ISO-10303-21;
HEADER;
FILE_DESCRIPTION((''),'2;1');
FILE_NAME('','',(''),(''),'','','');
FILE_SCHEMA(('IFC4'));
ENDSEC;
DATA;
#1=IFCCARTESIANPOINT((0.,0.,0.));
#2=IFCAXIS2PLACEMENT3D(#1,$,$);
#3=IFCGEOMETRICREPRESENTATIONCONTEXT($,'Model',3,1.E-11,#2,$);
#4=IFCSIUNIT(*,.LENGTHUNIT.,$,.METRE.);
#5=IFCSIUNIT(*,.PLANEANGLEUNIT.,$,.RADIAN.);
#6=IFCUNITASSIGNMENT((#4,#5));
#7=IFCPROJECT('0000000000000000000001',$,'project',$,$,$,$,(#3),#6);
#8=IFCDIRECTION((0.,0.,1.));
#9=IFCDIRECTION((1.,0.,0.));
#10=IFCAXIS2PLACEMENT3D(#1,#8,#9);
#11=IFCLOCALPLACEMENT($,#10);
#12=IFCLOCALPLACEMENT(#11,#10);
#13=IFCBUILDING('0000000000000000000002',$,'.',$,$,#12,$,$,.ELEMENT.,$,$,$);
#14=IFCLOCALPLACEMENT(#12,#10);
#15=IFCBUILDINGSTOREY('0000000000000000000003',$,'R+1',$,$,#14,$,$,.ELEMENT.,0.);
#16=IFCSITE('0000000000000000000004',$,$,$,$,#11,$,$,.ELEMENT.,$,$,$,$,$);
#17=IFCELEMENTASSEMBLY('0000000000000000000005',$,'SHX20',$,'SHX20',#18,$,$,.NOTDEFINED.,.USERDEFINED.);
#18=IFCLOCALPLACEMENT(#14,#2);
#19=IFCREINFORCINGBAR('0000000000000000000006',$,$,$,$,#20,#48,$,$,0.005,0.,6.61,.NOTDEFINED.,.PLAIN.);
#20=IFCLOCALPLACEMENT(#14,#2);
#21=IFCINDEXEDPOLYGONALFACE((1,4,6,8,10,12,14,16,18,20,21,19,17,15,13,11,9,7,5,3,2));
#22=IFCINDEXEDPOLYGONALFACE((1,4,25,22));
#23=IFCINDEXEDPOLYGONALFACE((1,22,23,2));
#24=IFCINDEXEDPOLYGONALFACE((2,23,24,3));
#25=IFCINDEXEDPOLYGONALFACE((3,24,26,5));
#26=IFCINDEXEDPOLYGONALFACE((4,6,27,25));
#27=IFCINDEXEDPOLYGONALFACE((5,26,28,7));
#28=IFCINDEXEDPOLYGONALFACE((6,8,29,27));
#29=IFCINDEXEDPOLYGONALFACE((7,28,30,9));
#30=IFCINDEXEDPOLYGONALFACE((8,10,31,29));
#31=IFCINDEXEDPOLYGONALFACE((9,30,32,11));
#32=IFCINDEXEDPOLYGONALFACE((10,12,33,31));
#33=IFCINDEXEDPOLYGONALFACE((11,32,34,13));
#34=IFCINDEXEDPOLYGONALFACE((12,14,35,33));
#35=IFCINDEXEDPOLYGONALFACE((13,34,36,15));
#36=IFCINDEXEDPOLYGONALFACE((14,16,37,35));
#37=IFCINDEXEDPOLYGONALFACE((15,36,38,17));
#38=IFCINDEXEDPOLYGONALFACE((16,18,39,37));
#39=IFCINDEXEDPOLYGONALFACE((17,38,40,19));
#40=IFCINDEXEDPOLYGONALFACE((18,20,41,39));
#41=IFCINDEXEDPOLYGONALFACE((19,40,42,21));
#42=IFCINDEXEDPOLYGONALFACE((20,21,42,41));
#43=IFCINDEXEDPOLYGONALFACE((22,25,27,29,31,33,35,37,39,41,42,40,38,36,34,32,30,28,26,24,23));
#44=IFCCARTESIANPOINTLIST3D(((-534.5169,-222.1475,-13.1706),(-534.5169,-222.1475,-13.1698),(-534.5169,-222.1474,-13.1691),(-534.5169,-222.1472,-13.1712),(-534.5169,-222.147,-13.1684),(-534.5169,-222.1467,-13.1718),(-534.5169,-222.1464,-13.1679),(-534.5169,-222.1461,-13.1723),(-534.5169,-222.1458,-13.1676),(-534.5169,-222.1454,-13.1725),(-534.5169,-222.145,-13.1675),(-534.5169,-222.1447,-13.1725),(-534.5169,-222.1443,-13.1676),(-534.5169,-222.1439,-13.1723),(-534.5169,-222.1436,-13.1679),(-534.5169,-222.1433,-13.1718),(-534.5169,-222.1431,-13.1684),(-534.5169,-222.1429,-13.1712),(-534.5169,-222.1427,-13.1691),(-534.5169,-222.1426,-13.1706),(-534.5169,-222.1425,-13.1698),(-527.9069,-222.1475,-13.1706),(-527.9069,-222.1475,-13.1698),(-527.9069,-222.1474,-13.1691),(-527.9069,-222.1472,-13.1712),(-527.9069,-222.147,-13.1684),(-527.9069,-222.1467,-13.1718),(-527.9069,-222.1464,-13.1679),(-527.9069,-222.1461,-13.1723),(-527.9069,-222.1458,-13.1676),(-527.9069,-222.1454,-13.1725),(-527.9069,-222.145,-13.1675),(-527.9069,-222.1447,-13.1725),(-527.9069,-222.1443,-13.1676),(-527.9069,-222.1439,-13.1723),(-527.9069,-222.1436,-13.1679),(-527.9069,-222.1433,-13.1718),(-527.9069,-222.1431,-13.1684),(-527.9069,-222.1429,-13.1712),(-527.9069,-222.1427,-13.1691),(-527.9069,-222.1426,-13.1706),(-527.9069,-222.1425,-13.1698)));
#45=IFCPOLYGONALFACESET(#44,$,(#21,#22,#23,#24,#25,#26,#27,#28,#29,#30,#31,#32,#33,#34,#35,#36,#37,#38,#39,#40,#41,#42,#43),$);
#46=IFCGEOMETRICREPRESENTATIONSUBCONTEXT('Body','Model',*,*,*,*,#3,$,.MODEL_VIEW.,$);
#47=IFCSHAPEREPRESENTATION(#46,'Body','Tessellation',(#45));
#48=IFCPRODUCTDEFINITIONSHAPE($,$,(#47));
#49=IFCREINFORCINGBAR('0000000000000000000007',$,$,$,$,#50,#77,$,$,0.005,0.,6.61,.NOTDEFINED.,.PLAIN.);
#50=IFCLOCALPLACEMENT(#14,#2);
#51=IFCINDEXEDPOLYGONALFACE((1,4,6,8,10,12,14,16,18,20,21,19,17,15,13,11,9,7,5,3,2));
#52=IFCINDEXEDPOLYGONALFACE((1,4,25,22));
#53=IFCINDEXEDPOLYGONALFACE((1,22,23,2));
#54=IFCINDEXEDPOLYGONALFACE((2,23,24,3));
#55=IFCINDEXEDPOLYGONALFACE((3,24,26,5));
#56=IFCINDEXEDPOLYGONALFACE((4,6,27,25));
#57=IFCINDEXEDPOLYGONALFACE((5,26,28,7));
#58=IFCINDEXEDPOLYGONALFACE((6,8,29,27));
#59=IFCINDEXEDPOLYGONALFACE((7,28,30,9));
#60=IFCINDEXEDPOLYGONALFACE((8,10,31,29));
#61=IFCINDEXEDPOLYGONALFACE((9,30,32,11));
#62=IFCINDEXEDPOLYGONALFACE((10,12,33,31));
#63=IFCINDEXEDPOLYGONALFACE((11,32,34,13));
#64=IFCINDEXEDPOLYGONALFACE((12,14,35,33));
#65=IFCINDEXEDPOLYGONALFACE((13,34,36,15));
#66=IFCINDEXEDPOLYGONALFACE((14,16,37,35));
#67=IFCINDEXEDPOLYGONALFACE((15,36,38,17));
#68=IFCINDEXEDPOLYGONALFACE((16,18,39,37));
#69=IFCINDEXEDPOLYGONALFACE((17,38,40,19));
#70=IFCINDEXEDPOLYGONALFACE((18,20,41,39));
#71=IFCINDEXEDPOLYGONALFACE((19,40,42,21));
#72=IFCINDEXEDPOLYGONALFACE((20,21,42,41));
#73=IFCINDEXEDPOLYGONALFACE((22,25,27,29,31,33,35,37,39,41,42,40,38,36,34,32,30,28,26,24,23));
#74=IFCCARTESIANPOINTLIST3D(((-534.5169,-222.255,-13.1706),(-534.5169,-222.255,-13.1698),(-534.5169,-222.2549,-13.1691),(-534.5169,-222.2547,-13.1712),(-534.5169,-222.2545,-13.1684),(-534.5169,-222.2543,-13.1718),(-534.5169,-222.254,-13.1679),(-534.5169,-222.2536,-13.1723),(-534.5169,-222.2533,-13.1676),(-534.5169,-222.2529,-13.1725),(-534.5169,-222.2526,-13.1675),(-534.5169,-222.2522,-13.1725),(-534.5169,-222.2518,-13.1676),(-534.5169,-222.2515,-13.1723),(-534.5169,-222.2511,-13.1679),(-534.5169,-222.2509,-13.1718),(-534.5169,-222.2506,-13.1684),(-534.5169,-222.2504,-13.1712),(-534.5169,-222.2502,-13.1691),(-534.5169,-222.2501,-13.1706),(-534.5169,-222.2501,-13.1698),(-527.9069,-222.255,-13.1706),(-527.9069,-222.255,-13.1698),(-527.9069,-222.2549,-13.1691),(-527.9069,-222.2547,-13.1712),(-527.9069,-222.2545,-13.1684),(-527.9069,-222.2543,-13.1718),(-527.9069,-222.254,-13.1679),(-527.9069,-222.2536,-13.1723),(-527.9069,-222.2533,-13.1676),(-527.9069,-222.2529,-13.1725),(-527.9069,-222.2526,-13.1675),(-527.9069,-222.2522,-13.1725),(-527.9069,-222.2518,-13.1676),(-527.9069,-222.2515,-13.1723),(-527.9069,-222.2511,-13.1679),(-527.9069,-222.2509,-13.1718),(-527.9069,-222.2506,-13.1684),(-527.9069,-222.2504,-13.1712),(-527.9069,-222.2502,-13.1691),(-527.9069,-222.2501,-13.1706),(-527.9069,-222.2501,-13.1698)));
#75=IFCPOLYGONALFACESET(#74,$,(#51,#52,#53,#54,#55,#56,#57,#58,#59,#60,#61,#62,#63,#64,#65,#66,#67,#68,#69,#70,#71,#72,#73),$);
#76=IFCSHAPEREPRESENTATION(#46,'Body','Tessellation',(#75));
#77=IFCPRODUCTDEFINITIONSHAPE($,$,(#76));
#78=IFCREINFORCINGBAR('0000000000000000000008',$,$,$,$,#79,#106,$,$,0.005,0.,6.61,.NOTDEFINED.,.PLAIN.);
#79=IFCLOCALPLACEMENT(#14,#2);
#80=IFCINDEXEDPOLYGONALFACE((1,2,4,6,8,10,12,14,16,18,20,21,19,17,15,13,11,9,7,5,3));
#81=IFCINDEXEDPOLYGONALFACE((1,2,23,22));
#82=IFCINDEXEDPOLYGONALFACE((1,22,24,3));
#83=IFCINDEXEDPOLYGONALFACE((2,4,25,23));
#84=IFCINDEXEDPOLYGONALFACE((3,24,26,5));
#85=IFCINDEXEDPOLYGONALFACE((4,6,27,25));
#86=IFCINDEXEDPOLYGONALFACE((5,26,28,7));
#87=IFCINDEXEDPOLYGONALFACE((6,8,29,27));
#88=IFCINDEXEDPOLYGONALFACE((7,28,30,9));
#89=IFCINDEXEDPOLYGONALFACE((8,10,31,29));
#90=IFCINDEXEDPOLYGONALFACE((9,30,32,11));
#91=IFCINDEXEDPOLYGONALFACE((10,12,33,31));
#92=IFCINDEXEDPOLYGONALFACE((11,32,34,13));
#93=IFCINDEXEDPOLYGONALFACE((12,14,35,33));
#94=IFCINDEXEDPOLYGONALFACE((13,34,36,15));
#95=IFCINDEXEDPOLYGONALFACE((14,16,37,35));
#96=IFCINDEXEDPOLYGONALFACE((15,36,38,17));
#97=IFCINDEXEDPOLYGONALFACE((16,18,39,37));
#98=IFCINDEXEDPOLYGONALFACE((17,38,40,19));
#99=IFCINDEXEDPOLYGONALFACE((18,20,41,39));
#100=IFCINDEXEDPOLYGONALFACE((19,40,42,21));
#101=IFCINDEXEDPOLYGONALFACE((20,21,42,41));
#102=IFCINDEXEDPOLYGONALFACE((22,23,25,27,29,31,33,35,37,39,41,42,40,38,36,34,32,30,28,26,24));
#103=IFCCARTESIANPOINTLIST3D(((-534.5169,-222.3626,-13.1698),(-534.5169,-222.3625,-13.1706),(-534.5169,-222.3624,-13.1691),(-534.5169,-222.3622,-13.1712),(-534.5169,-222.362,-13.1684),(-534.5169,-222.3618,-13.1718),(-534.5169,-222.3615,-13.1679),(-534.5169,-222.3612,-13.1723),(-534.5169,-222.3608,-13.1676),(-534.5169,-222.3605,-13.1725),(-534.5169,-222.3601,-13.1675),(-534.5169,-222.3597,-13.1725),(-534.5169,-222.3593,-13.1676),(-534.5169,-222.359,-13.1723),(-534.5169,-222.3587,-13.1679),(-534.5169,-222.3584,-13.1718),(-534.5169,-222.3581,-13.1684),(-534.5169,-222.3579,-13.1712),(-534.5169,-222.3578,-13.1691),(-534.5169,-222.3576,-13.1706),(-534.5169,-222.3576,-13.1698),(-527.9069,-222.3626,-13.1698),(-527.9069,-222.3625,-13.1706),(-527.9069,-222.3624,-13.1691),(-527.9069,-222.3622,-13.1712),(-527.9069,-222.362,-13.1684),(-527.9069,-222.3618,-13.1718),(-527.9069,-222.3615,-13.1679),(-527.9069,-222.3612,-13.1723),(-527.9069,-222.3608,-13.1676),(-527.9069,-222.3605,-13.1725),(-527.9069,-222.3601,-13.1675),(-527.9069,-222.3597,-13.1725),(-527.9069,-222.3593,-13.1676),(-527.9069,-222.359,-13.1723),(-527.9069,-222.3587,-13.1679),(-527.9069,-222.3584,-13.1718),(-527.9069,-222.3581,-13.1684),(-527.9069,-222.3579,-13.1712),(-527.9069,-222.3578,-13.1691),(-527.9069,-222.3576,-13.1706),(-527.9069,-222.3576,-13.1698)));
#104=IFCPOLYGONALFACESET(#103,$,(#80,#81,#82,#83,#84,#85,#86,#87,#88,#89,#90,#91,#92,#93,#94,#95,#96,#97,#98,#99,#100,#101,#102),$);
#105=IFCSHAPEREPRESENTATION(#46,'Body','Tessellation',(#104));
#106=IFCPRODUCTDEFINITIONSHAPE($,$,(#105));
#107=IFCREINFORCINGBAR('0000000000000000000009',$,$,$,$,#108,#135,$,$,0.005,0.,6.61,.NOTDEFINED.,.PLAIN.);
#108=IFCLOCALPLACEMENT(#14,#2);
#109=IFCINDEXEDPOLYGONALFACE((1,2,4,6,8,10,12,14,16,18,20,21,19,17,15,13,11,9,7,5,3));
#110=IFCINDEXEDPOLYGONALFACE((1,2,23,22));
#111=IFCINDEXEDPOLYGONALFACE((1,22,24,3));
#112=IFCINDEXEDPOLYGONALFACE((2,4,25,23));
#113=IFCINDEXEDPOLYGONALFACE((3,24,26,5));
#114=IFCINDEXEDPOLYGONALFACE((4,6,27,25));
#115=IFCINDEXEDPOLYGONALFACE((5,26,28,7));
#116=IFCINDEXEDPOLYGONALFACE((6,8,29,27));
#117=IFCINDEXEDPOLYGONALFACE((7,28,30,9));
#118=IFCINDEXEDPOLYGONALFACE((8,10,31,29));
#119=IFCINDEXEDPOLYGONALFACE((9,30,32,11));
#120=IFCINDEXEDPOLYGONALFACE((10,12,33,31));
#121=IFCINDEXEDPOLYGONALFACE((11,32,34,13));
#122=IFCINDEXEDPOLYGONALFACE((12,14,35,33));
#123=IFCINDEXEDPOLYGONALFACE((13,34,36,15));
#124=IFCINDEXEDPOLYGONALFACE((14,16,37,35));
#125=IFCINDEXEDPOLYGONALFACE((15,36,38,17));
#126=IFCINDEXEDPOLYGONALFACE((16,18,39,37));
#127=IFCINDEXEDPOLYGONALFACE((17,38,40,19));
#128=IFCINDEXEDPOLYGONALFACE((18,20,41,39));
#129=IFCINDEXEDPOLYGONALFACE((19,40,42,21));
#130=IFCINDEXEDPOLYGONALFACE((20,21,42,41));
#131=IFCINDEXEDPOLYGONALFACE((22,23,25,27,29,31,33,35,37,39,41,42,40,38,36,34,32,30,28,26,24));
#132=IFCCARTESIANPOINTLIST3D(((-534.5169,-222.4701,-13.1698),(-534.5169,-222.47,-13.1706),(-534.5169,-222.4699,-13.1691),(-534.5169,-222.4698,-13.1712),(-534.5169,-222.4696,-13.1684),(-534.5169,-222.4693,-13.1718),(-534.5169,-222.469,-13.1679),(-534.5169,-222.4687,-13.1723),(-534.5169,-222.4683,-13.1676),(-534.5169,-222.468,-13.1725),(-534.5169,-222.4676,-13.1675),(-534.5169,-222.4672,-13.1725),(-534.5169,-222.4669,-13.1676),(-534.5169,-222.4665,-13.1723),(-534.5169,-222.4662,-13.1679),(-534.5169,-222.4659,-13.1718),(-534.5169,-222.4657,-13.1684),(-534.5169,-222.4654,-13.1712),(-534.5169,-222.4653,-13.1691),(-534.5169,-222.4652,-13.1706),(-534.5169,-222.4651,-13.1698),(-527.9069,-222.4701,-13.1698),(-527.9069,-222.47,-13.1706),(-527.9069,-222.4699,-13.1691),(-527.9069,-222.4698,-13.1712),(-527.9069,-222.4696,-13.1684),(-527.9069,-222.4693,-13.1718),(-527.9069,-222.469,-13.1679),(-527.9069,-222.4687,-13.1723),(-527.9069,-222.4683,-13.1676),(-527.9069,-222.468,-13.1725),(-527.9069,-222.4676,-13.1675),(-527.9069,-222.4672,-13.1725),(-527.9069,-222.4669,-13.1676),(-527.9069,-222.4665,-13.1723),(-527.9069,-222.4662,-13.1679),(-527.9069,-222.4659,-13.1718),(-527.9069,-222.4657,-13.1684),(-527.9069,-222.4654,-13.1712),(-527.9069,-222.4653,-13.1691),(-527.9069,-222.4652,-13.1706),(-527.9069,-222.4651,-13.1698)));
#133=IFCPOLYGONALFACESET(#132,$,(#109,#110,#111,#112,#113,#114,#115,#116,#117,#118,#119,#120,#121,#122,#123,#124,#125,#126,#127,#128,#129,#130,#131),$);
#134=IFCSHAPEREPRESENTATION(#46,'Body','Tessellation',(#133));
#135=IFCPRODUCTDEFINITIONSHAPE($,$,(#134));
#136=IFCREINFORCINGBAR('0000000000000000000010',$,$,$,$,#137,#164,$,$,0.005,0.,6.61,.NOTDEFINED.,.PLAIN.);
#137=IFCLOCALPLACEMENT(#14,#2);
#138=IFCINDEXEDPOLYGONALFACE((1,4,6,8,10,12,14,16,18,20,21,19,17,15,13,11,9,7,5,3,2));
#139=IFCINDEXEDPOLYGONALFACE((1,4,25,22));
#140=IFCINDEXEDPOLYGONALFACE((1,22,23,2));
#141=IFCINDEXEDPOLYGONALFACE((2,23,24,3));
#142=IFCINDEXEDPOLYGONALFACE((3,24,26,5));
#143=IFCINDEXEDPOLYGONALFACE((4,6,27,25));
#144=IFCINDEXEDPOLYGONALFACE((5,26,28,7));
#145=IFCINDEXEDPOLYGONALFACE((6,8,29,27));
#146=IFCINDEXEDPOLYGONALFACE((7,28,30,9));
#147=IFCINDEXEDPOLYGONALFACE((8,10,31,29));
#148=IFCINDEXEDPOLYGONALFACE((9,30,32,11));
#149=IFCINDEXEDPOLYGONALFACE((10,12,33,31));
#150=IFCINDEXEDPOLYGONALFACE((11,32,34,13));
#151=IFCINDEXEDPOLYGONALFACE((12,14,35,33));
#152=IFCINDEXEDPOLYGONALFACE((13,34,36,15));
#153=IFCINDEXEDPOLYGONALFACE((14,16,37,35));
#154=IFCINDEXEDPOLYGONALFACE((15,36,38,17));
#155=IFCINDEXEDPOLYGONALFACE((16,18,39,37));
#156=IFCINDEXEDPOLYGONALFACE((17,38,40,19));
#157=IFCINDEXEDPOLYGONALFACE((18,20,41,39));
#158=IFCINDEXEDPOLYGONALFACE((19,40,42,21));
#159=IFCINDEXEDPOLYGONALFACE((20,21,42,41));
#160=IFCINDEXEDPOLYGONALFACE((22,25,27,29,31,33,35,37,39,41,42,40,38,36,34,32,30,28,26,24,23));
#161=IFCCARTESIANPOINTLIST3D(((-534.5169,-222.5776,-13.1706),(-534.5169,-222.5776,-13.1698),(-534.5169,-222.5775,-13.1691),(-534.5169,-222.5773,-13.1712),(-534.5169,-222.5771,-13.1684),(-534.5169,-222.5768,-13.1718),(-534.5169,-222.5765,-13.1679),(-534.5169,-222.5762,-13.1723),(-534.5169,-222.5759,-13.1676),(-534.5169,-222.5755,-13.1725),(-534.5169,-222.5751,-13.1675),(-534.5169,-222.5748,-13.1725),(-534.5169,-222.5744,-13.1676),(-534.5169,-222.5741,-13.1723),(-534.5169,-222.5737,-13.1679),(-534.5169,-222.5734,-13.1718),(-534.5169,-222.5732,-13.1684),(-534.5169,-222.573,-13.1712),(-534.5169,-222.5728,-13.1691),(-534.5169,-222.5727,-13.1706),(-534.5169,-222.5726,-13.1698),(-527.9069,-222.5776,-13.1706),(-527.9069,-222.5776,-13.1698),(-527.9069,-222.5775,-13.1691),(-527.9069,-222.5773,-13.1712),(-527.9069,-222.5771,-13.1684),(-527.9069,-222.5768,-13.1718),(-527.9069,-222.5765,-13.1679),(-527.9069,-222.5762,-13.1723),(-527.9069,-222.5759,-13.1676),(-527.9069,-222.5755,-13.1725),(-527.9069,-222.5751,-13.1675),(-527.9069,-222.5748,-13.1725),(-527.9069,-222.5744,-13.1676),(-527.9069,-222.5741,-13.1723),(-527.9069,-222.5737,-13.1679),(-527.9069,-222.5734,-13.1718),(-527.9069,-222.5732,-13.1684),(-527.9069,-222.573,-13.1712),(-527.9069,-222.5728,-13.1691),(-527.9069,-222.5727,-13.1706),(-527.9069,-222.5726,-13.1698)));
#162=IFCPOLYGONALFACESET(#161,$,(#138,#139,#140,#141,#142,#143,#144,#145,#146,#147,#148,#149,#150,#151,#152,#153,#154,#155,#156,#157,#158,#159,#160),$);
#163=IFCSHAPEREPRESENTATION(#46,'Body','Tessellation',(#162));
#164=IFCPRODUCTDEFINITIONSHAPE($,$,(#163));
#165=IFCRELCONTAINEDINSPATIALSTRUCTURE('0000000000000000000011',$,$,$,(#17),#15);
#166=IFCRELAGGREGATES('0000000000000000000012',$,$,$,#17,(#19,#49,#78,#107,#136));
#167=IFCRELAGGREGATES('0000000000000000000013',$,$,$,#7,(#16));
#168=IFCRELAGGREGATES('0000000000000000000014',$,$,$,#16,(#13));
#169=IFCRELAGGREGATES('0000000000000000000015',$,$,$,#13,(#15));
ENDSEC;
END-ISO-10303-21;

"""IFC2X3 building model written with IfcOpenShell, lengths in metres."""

from ifc_helpers import new_model, entity, si_unit, origin, origin_with_axes, place, context, subcontext, project, spatial, shape, element, aggregate, save


model = new_model("IFC2X3")

# Units and contexts
model_context = context("Model", 3, precision=1e-11, world=origin())
body_context = subcontext(model_context, "Body", "Model", "MODEL_VIEW")
ifc_project = project(units=[si_unit("LENGTHUNIT", "METRE"), si_unit("PLANEANGLEUNIT", "RADIAN")], contexts=[model_context])

# Site, building, storey
site_placement = place(None, origin_with_axes())
site = spatial("IfcSite", under=ifc_project, at=site_placement, CompositionType="ELEMENT")
building_placement = place(site_placement, origin_with_axes())
building = spatial("IfcBuilding", under=site, at=building_placement, Name=".", CompositionType="ELEMENT")
storey_placement = place(building_placement, origin_with_axes())
storey = spatial("IfcBuildingStorey", under=building, at=storey_placement, Name="R+1", CompositionType="ELEMENT", Elevation=0.0)

# Element assembly, reinforcing bars
assembly_1_placement = place(storey_placement, origin_with_axes())
assembly_1 = element("IfcElementAssembly", 1, at=assembly_1_placement, inside=storey, Name="SHX20", ObjectType="SHX20", AssemblyPlace="NOTDEFINED", PredefinedType="USERDEFINED")
reinforcing_bar_1_placement = place(assembly_1_placement, origin_with_axes())
reinforcing_bar_1 = element("IfcReinforcingBar", 2, at=reinforcing_bar_1_placement, BarLength=6.61, BarRole="NOTDEFINED", BarSurface="PLAIN", CrossSectionArea=0.0, NominalDiameter=0.005, shapes=[
    shape(body_context, "Body", "AdvancedSweptSolid", [entity("IfcSweptDiskSolid", entity("IfcPolyline", [entity("IfcCartesianPoint", [527.9069, 222.145, 13.17]), entity("IfcCartesianPoint", [534.5169, 222.145, 13.17])]), 0.0025, None, 0.0, 6.61)]),
    shape(body_context, "Body", "AdvancedSweptSolid", [entity("IfcSweptDiskSolid", entity("IfcPolyline", [entity("IfcCartesianPoint", [527.9069, 222.145, 13.17]), entity("IfcCartesianPoint", [534.5169, 222.145, 13.17])]), 0.0025, None, 0.0, 6.61)]),
])
reinforcing_bar_2_placement = place(assembly_1_placement, origin_with_axes())
reinforcing_bar_2 = element("IfcReinforcingBar", 3, at=reinforcing_bar_2_placement, BarLength=6.61, BarRole="NOTDEFINED", BarSurface="PLAIN", CrossSectionArea=0.0, NominalDiameter=0.005, shapes=[
    shape(body_context, "Body", "AdvancedSweptSolid", [entity("IfcSweptDiskSolid", entity("IfcPolyline", [entity("IfcCartesianPoint", [527.9069, 222.2526, 13.17]), entity("IfcCartesianPoint", [534.5169, 222.2526, 13.17])]), 0.0025, None, 0.0, 6.61)]),
    shape(body_context, "Body", "AdvancedSweptSolid", [entity("IfcSweptDiskSolid", entity("IfcPolyline", [entity("IfcCartesianPoint", [527.9069, 222.2526, 13.17]), entity("IfcCartesianPoint", [534.5169, 222.2526, 13.17])]), 0.0025, None, 0.0, 6.61)]),
])
reinforcing_bar_3_placement = place(assembly_1_placement, origin_with_axes())
reinforcing_bar_3 = element("IfcReinforcingBar", 4, at=reinforcing_bar_3_placement, BarLength=6.61, BarRole="NOTDEFINED", BarSurface="PLAIN", CrossSectionArea=0.0, NominalDiameter=0.005, shapes=[
    shape(body_context, "Body", "AdvancedSweptSolid", [entity("IfcSweptDiskSolid", entity("IfcPolyline", [entity("IfcCartesianPoint", [527.9069, 222.3601, 13.17]), entity("IfcCartesianPoint", [534.5169, 222.3601, 13.17])]), 0.0025, None, 0.0, 6.61)]),
    shape(body_context, "Body", "AdvancedSweptSolid", [entity("IfcSweptDiskSolid", entity("IfcPolyline", [entity("IfcCartesianPoint", [527.9069, 222.3601, 13.17]), entity("IfcCartesianPoint", [534.5169, 222.3601, 13.17])]), 0.0025, None, 0.0, 6.61)]),
])
reinforcing_bar_4_placement = place(assembly_1_placement, origin_with_axes())
reinforcing_bar_4 = element("IfcReinforcingBar", 5, at=reinforcing_bar_4_placement, BarLength=6.61, BarRole="NOTDEFINED", BarSurface="PLAIN", CrossSectionArea=0.0, NominalDiameter=0.005, shapes=[
    shape(body_context, "Body", "AdvancedSweptSolid", [entity("IfcSweptDiskSolid", entity("IfcPolyline", [entity("IfcCartesianPoint", [527.9069, 222.4676, 13.17]), entity("IfcCartesianPoint", [534.5169, 222.4676, 13.17])]), 0.0025, None, 0.0, 6.61)]),
    shape(body_context, "Body", "AdvancedSweptSolid", [entity("IfcSweptDiskSolid", entity("IfcPolyline", [entity("IfcCartesianPoint", [527.9069, 222.4676, 13.17]), entity("IfcCartesianPoint", [534.5169, 222.4676, 13.17])]), 0.0025, None, 0.0, 6.61)]),
])
reinforcing_bar_5_placement = place(assembly_1_placement, origin_with_axes())
reinforcing_bar_5 = element("IfcReinforcingBar", 6, at=reinforcing_bar_5_placement, BarLength=6.61, BarRole="NOTDEFINED", BarSurface="PLAIN", CrossSectionArea=0.0, NominalDiameter=0.005, shapes=[
    shape(body_context, "Body", "AdvancedSweptSolid", [entity("IfcSweptDiskSolid", entity("IfcPolyline", [entity("IfcCartesianPoint", [527.9069, 222.5751, 13.17]), entity("IfcCartesianPoint", [534.5169, 222.5751, 13.17])]), 0.0025, None, 0.0, 6.61)]),
    shape(body_context, "Body", "AdvancedSweptSolid", [entity("IfcSweptDiskSolid", entity("IfcPolyline", [entity("IfcCartesianPoint", [527.9069, 222.5751, 13.17]), entity("IfcCartesianPoint", [534.5169, 222.5751, 13.17])]), 0.0025, None, 0.0, 6.61)]),
])
aggregate(assembly_1, [reinforcing_bar_1, reinforcing_bar_2, reinforcing_bar_3, reinforcing_bar_4, reinforcing_bar_5])

save(model, "model.ifc")
